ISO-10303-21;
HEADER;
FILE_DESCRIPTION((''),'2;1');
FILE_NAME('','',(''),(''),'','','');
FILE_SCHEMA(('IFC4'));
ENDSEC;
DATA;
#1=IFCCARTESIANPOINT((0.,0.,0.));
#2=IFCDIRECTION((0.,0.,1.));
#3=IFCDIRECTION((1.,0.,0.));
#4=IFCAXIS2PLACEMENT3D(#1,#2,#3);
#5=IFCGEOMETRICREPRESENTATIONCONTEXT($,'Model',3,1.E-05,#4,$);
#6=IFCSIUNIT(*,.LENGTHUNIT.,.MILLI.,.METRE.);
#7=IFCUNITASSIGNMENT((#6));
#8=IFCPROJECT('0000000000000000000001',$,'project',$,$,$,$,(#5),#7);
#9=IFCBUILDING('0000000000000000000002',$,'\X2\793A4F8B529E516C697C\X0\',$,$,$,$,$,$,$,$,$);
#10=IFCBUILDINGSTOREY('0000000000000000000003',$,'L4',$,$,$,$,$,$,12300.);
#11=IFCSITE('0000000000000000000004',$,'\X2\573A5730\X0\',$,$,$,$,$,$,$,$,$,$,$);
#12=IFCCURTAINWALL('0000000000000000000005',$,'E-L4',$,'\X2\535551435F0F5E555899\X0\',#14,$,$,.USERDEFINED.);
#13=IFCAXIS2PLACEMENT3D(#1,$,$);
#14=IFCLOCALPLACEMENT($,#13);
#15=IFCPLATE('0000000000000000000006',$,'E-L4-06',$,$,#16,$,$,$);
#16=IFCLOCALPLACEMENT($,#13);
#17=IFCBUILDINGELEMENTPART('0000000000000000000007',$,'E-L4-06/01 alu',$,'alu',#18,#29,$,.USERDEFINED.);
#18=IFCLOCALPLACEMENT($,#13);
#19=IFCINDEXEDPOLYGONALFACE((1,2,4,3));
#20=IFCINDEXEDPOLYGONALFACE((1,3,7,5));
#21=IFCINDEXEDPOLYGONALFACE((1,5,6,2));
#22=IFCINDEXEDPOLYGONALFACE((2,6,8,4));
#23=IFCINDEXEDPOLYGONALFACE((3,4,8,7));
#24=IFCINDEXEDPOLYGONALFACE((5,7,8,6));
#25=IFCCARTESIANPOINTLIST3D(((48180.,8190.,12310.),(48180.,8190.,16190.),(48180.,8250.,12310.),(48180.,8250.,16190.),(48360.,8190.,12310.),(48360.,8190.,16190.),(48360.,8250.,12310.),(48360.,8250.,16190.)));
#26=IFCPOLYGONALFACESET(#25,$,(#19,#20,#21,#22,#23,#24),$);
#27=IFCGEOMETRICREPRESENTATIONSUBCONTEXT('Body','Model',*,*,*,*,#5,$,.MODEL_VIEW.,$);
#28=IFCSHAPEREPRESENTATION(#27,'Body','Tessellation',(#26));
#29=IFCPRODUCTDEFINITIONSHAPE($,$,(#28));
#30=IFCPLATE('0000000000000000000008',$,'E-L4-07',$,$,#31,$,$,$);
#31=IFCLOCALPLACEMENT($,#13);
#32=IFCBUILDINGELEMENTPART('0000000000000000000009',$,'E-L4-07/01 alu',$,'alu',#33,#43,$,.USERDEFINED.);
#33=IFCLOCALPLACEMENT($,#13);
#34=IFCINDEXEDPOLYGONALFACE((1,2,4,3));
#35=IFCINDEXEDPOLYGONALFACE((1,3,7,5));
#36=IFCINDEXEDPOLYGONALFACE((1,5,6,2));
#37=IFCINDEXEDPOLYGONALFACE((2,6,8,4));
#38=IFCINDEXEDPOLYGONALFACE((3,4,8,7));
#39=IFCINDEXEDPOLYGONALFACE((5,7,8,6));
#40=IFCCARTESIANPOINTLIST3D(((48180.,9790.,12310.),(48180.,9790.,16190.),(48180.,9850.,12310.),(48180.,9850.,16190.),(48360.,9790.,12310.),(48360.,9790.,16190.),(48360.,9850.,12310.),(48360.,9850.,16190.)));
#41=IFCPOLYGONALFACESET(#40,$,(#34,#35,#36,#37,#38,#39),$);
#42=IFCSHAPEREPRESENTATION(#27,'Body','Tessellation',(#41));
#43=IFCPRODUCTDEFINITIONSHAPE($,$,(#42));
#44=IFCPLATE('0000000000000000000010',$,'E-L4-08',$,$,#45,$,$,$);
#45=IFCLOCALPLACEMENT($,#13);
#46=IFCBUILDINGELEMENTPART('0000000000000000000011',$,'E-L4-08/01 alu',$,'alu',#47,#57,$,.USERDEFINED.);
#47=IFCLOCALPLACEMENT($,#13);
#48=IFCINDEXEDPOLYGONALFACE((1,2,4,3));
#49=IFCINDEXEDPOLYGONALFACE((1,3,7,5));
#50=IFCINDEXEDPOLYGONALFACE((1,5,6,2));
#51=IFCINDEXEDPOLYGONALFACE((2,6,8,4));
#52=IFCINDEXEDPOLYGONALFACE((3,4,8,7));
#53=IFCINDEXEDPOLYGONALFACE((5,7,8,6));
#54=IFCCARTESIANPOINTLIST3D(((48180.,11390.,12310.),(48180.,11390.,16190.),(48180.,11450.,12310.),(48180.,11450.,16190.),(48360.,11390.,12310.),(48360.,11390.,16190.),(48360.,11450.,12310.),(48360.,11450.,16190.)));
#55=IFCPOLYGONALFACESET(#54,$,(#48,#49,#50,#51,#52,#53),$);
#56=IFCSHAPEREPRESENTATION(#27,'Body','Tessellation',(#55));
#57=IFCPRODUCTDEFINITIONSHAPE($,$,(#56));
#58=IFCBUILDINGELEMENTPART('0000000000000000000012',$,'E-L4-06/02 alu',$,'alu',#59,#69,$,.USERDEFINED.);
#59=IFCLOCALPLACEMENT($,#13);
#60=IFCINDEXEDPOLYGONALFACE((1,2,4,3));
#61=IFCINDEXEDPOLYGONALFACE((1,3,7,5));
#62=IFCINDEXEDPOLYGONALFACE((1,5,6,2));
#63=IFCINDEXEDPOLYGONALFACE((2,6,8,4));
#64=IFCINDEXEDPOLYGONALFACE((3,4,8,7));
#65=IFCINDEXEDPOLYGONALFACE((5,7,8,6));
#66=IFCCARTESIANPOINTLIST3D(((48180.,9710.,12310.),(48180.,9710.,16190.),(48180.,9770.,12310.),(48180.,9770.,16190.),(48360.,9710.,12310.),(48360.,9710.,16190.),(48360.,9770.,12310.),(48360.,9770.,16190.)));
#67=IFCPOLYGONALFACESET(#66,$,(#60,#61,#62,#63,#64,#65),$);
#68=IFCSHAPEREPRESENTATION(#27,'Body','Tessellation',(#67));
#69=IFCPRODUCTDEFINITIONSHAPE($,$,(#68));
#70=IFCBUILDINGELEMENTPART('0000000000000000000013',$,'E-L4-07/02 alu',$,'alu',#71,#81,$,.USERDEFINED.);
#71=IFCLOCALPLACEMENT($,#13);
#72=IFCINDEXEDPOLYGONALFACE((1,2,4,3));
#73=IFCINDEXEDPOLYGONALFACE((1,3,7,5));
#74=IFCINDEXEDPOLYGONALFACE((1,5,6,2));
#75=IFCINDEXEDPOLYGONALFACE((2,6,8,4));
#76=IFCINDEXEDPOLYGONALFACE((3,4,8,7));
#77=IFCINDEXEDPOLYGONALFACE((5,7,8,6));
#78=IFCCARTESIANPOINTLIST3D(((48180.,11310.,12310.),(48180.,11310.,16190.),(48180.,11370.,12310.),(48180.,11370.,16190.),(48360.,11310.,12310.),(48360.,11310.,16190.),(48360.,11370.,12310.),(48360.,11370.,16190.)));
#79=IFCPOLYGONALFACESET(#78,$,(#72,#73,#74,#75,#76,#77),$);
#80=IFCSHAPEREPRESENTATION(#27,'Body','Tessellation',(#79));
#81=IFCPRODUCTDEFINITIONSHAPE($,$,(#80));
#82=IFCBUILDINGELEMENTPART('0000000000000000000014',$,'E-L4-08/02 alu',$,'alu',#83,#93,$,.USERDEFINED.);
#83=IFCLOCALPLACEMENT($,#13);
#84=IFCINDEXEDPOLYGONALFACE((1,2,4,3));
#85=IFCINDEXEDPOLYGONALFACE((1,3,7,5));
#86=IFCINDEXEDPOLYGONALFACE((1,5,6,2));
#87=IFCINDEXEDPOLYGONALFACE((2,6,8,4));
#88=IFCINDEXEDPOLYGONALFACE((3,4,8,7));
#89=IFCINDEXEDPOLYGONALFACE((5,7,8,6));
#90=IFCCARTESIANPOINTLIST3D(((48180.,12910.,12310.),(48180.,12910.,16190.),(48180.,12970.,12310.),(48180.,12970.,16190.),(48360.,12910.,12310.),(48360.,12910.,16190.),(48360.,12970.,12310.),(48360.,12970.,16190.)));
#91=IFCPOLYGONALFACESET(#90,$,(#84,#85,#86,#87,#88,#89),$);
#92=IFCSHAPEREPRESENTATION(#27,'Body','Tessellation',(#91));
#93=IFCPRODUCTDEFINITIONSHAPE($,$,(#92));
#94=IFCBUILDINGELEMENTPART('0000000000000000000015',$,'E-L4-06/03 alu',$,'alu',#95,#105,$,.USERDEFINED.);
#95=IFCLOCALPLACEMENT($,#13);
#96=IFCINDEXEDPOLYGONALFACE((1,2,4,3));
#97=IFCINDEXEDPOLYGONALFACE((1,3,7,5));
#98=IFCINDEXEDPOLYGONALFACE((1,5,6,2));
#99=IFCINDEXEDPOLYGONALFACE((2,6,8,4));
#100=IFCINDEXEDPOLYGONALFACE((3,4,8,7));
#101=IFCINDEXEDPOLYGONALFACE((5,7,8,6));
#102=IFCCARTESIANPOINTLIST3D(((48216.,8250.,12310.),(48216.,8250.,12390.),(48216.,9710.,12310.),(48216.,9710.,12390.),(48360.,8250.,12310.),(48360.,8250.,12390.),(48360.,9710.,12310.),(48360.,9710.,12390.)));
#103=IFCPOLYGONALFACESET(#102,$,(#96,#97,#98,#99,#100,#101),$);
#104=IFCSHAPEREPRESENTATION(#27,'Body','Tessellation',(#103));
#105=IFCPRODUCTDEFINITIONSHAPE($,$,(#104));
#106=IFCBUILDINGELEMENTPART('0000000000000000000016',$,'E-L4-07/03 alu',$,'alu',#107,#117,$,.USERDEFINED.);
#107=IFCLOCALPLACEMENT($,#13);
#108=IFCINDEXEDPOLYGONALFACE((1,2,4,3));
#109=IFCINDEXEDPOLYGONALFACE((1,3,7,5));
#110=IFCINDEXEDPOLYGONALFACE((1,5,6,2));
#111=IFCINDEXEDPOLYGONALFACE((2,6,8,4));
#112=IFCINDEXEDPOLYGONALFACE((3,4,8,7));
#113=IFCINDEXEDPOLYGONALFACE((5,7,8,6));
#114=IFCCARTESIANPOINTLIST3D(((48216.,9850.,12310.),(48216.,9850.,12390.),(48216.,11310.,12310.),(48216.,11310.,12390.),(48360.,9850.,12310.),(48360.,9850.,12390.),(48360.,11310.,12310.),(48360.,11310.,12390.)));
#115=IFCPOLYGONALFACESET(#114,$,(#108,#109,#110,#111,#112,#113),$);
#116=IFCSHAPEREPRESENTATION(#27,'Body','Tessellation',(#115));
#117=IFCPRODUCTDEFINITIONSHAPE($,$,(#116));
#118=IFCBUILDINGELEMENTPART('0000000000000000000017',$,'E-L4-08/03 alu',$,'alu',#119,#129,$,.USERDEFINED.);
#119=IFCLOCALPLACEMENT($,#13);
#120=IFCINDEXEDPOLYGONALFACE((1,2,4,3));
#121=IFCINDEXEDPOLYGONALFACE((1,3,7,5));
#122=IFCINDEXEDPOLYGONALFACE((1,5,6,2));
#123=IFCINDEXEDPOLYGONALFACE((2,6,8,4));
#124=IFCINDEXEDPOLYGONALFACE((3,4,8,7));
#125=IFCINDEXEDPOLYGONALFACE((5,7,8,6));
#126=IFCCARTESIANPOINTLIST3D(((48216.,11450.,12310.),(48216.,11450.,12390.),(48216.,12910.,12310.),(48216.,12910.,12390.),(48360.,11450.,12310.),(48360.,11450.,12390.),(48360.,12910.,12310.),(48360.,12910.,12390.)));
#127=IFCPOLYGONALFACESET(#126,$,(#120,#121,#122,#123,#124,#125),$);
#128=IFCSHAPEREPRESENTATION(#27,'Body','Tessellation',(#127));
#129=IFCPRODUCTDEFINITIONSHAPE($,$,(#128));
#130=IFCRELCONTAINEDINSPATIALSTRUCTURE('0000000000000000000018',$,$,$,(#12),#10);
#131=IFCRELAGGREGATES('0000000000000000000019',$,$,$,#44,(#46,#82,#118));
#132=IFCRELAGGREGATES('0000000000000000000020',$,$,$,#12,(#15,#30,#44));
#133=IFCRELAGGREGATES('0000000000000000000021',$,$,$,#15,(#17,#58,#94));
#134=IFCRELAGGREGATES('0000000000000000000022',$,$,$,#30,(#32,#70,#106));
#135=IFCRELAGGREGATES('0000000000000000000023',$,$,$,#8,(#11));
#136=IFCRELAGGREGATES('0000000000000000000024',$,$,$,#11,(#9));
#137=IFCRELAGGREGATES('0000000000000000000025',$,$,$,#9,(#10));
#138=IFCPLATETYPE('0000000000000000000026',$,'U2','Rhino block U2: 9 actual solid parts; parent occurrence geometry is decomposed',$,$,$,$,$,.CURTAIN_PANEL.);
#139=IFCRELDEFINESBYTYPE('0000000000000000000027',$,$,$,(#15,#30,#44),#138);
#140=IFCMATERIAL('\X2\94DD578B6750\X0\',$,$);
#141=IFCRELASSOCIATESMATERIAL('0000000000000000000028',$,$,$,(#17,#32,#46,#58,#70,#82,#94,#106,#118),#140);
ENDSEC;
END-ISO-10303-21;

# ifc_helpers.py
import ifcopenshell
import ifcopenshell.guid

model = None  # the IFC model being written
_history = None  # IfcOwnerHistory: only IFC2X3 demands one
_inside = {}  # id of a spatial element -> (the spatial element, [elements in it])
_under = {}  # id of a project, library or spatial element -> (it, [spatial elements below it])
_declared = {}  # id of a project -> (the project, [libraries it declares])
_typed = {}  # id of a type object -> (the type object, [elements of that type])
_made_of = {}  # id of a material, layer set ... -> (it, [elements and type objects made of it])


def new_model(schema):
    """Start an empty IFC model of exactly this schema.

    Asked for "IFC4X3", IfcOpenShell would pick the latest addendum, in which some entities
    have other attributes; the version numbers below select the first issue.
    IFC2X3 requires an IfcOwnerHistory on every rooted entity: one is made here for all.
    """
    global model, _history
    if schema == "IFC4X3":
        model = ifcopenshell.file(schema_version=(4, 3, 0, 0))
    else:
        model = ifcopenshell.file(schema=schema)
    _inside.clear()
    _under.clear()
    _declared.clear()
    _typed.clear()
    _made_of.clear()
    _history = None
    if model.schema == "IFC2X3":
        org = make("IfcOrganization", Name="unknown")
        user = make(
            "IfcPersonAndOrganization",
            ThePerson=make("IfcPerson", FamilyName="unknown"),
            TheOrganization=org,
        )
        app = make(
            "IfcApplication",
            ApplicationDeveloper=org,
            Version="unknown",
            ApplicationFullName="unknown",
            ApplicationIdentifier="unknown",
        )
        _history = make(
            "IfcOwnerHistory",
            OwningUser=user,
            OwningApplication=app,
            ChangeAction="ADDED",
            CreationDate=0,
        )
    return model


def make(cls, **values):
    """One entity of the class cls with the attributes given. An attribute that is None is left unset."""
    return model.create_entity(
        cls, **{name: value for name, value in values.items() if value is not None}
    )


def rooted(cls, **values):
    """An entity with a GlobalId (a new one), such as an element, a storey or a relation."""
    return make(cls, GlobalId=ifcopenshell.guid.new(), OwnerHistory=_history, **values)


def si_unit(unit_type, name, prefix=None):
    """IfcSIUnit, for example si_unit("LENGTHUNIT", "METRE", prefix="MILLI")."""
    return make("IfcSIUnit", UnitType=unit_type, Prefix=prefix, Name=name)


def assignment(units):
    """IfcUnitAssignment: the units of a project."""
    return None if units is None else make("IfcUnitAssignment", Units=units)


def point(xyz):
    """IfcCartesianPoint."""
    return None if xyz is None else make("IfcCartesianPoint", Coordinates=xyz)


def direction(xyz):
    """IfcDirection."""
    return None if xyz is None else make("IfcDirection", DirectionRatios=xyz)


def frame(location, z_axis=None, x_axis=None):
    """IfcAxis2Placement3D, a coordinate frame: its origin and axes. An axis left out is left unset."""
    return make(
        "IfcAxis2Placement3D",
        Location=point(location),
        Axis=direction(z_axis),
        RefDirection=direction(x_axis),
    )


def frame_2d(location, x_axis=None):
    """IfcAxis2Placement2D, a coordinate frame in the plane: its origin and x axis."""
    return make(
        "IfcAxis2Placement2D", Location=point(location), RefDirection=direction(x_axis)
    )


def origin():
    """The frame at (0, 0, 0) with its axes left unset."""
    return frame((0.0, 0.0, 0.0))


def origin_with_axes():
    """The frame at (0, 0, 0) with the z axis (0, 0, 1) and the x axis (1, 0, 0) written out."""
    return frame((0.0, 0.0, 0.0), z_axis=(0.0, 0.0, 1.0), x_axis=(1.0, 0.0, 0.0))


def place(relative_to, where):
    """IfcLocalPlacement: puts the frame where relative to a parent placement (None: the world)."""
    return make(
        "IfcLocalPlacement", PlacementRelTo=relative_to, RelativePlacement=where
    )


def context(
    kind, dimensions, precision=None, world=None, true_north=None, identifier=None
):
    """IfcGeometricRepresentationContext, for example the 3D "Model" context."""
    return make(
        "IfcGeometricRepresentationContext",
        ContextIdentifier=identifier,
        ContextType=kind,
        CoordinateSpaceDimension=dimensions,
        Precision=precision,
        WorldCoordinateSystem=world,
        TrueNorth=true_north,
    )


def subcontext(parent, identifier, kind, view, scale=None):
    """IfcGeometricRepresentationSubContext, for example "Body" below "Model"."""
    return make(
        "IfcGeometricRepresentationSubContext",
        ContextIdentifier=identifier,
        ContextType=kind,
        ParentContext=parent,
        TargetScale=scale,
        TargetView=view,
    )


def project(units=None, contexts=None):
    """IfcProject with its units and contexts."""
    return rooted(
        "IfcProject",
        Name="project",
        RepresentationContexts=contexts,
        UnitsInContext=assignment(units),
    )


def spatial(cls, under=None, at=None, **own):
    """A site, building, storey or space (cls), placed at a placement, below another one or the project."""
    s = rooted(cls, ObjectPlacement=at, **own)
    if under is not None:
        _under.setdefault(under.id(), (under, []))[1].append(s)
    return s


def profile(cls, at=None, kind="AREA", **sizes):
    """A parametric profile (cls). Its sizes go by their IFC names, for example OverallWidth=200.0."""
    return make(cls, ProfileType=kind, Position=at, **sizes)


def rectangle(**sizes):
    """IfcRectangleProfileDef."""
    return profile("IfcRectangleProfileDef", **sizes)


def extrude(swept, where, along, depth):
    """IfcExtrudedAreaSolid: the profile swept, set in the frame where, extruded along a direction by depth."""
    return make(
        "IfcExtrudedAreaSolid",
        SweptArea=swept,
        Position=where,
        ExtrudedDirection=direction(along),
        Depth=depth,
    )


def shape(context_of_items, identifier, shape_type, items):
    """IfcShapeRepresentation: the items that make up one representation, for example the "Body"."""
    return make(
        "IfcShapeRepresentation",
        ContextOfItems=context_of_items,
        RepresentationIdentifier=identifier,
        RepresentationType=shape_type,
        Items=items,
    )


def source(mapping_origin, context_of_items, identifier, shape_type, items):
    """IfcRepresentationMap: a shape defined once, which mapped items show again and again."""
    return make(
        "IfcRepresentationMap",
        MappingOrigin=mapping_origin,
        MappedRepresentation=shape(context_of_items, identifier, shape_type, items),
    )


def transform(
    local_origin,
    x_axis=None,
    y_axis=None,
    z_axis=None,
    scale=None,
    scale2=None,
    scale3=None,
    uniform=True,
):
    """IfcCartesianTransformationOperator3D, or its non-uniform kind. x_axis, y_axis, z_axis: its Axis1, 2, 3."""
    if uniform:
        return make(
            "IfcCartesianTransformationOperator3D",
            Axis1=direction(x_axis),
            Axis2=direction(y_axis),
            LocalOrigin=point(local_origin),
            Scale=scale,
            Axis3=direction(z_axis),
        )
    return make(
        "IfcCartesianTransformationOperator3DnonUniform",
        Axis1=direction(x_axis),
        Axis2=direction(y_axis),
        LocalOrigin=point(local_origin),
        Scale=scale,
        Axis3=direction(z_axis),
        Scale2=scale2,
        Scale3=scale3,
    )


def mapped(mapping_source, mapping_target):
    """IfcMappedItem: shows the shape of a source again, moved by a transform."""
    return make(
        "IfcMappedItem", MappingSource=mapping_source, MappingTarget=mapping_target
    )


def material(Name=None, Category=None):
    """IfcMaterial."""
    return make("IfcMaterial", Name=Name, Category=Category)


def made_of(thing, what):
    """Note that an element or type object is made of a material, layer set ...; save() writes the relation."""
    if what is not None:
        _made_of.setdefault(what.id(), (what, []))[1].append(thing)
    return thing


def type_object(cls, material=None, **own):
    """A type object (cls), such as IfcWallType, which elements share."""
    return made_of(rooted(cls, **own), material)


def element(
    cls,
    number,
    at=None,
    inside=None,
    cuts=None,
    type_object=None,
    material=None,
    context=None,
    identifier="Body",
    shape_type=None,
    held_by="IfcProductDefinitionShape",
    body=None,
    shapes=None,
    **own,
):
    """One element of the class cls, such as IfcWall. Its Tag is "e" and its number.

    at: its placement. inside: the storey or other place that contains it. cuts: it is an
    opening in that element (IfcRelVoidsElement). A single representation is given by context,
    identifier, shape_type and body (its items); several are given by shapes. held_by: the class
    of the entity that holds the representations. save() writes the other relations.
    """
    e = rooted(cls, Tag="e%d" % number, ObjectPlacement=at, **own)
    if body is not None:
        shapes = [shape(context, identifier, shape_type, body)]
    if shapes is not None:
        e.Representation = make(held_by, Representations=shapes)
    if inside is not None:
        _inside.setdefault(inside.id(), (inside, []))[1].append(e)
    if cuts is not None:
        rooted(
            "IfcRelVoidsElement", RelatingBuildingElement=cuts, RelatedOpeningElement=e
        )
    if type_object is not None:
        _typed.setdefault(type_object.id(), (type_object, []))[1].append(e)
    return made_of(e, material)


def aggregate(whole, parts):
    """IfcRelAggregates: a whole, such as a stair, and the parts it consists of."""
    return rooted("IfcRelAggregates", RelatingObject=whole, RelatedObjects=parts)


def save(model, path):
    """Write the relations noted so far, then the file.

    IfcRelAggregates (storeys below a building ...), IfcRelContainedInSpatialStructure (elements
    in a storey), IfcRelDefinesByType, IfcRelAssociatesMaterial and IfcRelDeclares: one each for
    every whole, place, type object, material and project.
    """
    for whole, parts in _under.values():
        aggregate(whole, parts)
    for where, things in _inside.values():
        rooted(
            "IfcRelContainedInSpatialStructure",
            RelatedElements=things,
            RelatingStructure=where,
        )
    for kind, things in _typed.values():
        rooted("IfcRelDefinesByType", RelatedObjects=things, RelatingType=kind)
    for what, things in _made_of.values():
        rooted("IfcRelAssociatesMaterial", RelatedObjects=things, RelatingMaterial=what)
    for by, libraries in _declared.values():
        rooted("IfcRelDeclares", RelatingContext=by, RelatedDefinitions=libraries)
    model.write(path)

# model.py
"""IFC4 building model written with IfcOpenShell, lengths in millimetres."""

from ifc_helpers import new_model, si_unit, frame, frame_2d, origin, origin_with_axes, place, context, subcontext, project, spatial, rectangle, extrude, source, transform, mapped, material, type_object, element, aggregate, save


model = new_model("IFC4")

# Units and contexts
model_context = context("Model", 3, precision=1e-05, world=origin_with_axes())
body_context = subcontext(model_context, "Body", "Model", "MODEL_VIEW")
ifc_project = project(units=[si_unit("LENGTHUNIT", "METRE", prefix="MILLI")], contexts=[model_context])

# Site, building, storey
site = spatial("IfcSite", under=ifc_project, Name="场地")
building = spatial("IfcBuilding", under=site, Name="示例办公楼")
storey = spatial("IfcBuildingStorey", under=building, Name="L4", Elevation=12300.0)

# Curtain wall, plates, building element parts
curtain_wall = element("IfcCurtainWall", 1, inside=storey, Name="E-L4", ObjectType="单元式幕墙", PredefinedType="USERDEFINED")
plate_type = type_object("IfcPlateType", Name="U2", Description="Rhino block U2: 9 actual solid parts; parent occurrence geometry is decomposed", PredefinedType="CURTAIN_PANEL")
plate_1_placement = place(None, frame((48360.0, 8190.0, 12310.0), z_axis=(0.0, 0.0, 1.0), x_axis=(0.0, 1.0, 0.0)))
plate_1 = element("IfcPlate", 2, at=plate_1_placement, type_object=plate_type, Name="E-L4-06")
ifc_material_1 = material(Name="铝型材")
shared_shape_1 = source(origin(), body_context, "Body", "SweptSolid", [
    extrude(rectangle(XDim=60.0, YDim=180.0, at=frame_2d((30.0, 90.0))), origin(), (0.0, 0.0, 1.0), 3880.0),
])
building_element_part_1_placement = place(plate_1_placement, origin())
building_element_part_1 = element("IfcBuildingElementPart", 3, at=building_element_part_1_placement, material=ifc_material_1, Name="E-L4-06/01 alu", ObjectType="alu", PredefinedType="USERDEFINED", context=body_context, shape_type="MappedRepresentation", body=[
    mapped(shared_shape_1, transform((0.0, 0.0, 0.0))),
])
plate_2_placement = place(None, frame((48360.0, 9790.0, 12310.0), z_axis=(0.0, 0.0, 1.0), x_axis=(0.0, 1.0, 0.0)))
plate_2 = element("IfcPlate", 4, at=plate_2_placement, type_object=plate_type, Name="E-L4-07")
building_element_part_2_placement = place(plate_2_placement, origin())
building_element_part_2 = element("IfcBuildingElementPart", 5, at=building_element_part_2_placement, material=ifc_material_1, Name="E-L4-07/01 alu", ObjectType="alu", PredefinedType="USERDEFINED", context=body_context, shape_type="MappedRepresentation", body=[
    mapped(shared_shape_1, transform((0.0, 0.0, 0.0))),
])
plate_3_placement = place(None, frame((48360.0, 11390.0, 12310.0), z_axis=(0.0, 0.0, 1.0), x_axis=(0.0, 1.0, 0.0)))
plate_3 = element("IfcPlate", 6, at=plate_3_placement, type_object=plate_type, Name="E-L4-08")
building_element_part_3_placement = place(plate_3_placement, origin())
building_element_part_3 = element("IfcBuildingElementPart", 7, at=building_element_part_3_placement, material=ifc_material_1, Name="E-L4-08/01 alu", ObjectType="alu", PredefinedType="USERDEFINED", context=body_context, shape_type="MappedRepresentation", body=[
    mapped(shared_shape_1, transform((0.0, 0.0, 0.0))),
])
shared_shape_2 = source(origin(), body_context, "Body", "SweptSolid", [
    extrude(rectangle(XDim=60.0, YDim=180.0, at=frame_2d((1550.0, 90.0))), origin(), (0.0, 0.0, 1.0), 3880.0),
])
building_element_part_4_placement = place(plate_1_placement, origin())
building_element_part_4 = element("IfcBuildingElementPart", 8, at=building_element_part_4_placement, material=ifc_material_1, Name="E-L4-06/02 alu", ObjectType="alu", PredefinedType="USERDEFINED", context=body_context, shape_type="MappedRepresentation", body=[
    mapped(shared_shape_2, transform((0.0, 0.0, 0.0))),
])
building_element_part_5_placement = place(plate_2_placement, origin())
building_element_part_5 = element("IfcBuildingElementPart", 9, at=building_element_part_5_placement, material=ifc_material_1, Name="E-L4-07/02 alu", ObjectType="alu", PredefinedType="USERDEFINED", context=body_context, shape_type="MappedRepresentation", body=[
    mapped(shared_shape_2, transform((0.0, 0.0, 0.0))),
])
building_element_part_6_placement = place(plate_3_placement, origin())
building_element_part_6 = element("IfcBuildingElementPart", 10, at=building_element_part_6_placement, material=ifc_material_1, Name="E-L4-08/02 alu", ObjectType="alu", PredefinedType="USERDEFINED", context=body_context, shape_type="MappedRepresentation", body=[
    mapped(shared_shape_2, transform((0.0, 0.0, 0.0))),
])
shared_shape_3 = source(origin(), body_context, "Body", "SweptSolid", [
    extrude(rectangle(XDim=1460.0, YDim=144.0, at=frame_2d((790.0, 72.0))), origin(), (0.0, 0.0, 1.0), 80.0),
])
building_element_part_7_placement = place(plate_1_placement, origin())
building_element_part_7 = element("IfcBuildingElementPart", 11, at=building_element_part_7_placement, material=ifc_material_1, Name="E-L4-06/03 alu", ObjectType="alu", PredefinedType="USERDEFINED", context=body_context, shape_type="MappedRepresentation", body=[
    mapped(shared_shape_3, transform((0.0, 0.0, 0.0))),
])
building_element_part_8_placement = place(plate_2_placement, origin())
building_element_part_8 = element("IfcBuildingElementPart", 12, at=building_element_part_8_placement, material=ifc_material_1, Name="E-L4-07/03 alu", ObjectType="alu", PredefinedType="USERDEFINED", context=body_context, shape_type="MappedRepresentation", body=[
    mapped(shared_shape_3, transform((0.0, 0.0, 0.0))),
])
building_element_part_9_placement = place(plate_3_placement, origin())
building_element_part_9 = element("IfcBuildingElementPart", 13, at=building_element_part_9_placement, material=ifc_material_1, Name="E-L4-08/03 alu", ObjectType="alu", PredefinedType="USERDEFINED", context=body_context, shape_type="MappedRepresentation", body=[
    mapped(shared_shape_3, transform((0.0, 0.0, 0.0))),
])
aggregate(plate_3, [building_element_part_3, building_element_part_6, building_element_part_9])
aggregate(curtain_wall, [plate_1, plate_2, plate_3])
aggregate(plate_1, [building_element_part_1, building_element_part_4, building_element_part_7])
aggregate(plate_2, [building_element_part_2, building_element_part_5, building_element_part_8])

save(model, "model.ifc")
